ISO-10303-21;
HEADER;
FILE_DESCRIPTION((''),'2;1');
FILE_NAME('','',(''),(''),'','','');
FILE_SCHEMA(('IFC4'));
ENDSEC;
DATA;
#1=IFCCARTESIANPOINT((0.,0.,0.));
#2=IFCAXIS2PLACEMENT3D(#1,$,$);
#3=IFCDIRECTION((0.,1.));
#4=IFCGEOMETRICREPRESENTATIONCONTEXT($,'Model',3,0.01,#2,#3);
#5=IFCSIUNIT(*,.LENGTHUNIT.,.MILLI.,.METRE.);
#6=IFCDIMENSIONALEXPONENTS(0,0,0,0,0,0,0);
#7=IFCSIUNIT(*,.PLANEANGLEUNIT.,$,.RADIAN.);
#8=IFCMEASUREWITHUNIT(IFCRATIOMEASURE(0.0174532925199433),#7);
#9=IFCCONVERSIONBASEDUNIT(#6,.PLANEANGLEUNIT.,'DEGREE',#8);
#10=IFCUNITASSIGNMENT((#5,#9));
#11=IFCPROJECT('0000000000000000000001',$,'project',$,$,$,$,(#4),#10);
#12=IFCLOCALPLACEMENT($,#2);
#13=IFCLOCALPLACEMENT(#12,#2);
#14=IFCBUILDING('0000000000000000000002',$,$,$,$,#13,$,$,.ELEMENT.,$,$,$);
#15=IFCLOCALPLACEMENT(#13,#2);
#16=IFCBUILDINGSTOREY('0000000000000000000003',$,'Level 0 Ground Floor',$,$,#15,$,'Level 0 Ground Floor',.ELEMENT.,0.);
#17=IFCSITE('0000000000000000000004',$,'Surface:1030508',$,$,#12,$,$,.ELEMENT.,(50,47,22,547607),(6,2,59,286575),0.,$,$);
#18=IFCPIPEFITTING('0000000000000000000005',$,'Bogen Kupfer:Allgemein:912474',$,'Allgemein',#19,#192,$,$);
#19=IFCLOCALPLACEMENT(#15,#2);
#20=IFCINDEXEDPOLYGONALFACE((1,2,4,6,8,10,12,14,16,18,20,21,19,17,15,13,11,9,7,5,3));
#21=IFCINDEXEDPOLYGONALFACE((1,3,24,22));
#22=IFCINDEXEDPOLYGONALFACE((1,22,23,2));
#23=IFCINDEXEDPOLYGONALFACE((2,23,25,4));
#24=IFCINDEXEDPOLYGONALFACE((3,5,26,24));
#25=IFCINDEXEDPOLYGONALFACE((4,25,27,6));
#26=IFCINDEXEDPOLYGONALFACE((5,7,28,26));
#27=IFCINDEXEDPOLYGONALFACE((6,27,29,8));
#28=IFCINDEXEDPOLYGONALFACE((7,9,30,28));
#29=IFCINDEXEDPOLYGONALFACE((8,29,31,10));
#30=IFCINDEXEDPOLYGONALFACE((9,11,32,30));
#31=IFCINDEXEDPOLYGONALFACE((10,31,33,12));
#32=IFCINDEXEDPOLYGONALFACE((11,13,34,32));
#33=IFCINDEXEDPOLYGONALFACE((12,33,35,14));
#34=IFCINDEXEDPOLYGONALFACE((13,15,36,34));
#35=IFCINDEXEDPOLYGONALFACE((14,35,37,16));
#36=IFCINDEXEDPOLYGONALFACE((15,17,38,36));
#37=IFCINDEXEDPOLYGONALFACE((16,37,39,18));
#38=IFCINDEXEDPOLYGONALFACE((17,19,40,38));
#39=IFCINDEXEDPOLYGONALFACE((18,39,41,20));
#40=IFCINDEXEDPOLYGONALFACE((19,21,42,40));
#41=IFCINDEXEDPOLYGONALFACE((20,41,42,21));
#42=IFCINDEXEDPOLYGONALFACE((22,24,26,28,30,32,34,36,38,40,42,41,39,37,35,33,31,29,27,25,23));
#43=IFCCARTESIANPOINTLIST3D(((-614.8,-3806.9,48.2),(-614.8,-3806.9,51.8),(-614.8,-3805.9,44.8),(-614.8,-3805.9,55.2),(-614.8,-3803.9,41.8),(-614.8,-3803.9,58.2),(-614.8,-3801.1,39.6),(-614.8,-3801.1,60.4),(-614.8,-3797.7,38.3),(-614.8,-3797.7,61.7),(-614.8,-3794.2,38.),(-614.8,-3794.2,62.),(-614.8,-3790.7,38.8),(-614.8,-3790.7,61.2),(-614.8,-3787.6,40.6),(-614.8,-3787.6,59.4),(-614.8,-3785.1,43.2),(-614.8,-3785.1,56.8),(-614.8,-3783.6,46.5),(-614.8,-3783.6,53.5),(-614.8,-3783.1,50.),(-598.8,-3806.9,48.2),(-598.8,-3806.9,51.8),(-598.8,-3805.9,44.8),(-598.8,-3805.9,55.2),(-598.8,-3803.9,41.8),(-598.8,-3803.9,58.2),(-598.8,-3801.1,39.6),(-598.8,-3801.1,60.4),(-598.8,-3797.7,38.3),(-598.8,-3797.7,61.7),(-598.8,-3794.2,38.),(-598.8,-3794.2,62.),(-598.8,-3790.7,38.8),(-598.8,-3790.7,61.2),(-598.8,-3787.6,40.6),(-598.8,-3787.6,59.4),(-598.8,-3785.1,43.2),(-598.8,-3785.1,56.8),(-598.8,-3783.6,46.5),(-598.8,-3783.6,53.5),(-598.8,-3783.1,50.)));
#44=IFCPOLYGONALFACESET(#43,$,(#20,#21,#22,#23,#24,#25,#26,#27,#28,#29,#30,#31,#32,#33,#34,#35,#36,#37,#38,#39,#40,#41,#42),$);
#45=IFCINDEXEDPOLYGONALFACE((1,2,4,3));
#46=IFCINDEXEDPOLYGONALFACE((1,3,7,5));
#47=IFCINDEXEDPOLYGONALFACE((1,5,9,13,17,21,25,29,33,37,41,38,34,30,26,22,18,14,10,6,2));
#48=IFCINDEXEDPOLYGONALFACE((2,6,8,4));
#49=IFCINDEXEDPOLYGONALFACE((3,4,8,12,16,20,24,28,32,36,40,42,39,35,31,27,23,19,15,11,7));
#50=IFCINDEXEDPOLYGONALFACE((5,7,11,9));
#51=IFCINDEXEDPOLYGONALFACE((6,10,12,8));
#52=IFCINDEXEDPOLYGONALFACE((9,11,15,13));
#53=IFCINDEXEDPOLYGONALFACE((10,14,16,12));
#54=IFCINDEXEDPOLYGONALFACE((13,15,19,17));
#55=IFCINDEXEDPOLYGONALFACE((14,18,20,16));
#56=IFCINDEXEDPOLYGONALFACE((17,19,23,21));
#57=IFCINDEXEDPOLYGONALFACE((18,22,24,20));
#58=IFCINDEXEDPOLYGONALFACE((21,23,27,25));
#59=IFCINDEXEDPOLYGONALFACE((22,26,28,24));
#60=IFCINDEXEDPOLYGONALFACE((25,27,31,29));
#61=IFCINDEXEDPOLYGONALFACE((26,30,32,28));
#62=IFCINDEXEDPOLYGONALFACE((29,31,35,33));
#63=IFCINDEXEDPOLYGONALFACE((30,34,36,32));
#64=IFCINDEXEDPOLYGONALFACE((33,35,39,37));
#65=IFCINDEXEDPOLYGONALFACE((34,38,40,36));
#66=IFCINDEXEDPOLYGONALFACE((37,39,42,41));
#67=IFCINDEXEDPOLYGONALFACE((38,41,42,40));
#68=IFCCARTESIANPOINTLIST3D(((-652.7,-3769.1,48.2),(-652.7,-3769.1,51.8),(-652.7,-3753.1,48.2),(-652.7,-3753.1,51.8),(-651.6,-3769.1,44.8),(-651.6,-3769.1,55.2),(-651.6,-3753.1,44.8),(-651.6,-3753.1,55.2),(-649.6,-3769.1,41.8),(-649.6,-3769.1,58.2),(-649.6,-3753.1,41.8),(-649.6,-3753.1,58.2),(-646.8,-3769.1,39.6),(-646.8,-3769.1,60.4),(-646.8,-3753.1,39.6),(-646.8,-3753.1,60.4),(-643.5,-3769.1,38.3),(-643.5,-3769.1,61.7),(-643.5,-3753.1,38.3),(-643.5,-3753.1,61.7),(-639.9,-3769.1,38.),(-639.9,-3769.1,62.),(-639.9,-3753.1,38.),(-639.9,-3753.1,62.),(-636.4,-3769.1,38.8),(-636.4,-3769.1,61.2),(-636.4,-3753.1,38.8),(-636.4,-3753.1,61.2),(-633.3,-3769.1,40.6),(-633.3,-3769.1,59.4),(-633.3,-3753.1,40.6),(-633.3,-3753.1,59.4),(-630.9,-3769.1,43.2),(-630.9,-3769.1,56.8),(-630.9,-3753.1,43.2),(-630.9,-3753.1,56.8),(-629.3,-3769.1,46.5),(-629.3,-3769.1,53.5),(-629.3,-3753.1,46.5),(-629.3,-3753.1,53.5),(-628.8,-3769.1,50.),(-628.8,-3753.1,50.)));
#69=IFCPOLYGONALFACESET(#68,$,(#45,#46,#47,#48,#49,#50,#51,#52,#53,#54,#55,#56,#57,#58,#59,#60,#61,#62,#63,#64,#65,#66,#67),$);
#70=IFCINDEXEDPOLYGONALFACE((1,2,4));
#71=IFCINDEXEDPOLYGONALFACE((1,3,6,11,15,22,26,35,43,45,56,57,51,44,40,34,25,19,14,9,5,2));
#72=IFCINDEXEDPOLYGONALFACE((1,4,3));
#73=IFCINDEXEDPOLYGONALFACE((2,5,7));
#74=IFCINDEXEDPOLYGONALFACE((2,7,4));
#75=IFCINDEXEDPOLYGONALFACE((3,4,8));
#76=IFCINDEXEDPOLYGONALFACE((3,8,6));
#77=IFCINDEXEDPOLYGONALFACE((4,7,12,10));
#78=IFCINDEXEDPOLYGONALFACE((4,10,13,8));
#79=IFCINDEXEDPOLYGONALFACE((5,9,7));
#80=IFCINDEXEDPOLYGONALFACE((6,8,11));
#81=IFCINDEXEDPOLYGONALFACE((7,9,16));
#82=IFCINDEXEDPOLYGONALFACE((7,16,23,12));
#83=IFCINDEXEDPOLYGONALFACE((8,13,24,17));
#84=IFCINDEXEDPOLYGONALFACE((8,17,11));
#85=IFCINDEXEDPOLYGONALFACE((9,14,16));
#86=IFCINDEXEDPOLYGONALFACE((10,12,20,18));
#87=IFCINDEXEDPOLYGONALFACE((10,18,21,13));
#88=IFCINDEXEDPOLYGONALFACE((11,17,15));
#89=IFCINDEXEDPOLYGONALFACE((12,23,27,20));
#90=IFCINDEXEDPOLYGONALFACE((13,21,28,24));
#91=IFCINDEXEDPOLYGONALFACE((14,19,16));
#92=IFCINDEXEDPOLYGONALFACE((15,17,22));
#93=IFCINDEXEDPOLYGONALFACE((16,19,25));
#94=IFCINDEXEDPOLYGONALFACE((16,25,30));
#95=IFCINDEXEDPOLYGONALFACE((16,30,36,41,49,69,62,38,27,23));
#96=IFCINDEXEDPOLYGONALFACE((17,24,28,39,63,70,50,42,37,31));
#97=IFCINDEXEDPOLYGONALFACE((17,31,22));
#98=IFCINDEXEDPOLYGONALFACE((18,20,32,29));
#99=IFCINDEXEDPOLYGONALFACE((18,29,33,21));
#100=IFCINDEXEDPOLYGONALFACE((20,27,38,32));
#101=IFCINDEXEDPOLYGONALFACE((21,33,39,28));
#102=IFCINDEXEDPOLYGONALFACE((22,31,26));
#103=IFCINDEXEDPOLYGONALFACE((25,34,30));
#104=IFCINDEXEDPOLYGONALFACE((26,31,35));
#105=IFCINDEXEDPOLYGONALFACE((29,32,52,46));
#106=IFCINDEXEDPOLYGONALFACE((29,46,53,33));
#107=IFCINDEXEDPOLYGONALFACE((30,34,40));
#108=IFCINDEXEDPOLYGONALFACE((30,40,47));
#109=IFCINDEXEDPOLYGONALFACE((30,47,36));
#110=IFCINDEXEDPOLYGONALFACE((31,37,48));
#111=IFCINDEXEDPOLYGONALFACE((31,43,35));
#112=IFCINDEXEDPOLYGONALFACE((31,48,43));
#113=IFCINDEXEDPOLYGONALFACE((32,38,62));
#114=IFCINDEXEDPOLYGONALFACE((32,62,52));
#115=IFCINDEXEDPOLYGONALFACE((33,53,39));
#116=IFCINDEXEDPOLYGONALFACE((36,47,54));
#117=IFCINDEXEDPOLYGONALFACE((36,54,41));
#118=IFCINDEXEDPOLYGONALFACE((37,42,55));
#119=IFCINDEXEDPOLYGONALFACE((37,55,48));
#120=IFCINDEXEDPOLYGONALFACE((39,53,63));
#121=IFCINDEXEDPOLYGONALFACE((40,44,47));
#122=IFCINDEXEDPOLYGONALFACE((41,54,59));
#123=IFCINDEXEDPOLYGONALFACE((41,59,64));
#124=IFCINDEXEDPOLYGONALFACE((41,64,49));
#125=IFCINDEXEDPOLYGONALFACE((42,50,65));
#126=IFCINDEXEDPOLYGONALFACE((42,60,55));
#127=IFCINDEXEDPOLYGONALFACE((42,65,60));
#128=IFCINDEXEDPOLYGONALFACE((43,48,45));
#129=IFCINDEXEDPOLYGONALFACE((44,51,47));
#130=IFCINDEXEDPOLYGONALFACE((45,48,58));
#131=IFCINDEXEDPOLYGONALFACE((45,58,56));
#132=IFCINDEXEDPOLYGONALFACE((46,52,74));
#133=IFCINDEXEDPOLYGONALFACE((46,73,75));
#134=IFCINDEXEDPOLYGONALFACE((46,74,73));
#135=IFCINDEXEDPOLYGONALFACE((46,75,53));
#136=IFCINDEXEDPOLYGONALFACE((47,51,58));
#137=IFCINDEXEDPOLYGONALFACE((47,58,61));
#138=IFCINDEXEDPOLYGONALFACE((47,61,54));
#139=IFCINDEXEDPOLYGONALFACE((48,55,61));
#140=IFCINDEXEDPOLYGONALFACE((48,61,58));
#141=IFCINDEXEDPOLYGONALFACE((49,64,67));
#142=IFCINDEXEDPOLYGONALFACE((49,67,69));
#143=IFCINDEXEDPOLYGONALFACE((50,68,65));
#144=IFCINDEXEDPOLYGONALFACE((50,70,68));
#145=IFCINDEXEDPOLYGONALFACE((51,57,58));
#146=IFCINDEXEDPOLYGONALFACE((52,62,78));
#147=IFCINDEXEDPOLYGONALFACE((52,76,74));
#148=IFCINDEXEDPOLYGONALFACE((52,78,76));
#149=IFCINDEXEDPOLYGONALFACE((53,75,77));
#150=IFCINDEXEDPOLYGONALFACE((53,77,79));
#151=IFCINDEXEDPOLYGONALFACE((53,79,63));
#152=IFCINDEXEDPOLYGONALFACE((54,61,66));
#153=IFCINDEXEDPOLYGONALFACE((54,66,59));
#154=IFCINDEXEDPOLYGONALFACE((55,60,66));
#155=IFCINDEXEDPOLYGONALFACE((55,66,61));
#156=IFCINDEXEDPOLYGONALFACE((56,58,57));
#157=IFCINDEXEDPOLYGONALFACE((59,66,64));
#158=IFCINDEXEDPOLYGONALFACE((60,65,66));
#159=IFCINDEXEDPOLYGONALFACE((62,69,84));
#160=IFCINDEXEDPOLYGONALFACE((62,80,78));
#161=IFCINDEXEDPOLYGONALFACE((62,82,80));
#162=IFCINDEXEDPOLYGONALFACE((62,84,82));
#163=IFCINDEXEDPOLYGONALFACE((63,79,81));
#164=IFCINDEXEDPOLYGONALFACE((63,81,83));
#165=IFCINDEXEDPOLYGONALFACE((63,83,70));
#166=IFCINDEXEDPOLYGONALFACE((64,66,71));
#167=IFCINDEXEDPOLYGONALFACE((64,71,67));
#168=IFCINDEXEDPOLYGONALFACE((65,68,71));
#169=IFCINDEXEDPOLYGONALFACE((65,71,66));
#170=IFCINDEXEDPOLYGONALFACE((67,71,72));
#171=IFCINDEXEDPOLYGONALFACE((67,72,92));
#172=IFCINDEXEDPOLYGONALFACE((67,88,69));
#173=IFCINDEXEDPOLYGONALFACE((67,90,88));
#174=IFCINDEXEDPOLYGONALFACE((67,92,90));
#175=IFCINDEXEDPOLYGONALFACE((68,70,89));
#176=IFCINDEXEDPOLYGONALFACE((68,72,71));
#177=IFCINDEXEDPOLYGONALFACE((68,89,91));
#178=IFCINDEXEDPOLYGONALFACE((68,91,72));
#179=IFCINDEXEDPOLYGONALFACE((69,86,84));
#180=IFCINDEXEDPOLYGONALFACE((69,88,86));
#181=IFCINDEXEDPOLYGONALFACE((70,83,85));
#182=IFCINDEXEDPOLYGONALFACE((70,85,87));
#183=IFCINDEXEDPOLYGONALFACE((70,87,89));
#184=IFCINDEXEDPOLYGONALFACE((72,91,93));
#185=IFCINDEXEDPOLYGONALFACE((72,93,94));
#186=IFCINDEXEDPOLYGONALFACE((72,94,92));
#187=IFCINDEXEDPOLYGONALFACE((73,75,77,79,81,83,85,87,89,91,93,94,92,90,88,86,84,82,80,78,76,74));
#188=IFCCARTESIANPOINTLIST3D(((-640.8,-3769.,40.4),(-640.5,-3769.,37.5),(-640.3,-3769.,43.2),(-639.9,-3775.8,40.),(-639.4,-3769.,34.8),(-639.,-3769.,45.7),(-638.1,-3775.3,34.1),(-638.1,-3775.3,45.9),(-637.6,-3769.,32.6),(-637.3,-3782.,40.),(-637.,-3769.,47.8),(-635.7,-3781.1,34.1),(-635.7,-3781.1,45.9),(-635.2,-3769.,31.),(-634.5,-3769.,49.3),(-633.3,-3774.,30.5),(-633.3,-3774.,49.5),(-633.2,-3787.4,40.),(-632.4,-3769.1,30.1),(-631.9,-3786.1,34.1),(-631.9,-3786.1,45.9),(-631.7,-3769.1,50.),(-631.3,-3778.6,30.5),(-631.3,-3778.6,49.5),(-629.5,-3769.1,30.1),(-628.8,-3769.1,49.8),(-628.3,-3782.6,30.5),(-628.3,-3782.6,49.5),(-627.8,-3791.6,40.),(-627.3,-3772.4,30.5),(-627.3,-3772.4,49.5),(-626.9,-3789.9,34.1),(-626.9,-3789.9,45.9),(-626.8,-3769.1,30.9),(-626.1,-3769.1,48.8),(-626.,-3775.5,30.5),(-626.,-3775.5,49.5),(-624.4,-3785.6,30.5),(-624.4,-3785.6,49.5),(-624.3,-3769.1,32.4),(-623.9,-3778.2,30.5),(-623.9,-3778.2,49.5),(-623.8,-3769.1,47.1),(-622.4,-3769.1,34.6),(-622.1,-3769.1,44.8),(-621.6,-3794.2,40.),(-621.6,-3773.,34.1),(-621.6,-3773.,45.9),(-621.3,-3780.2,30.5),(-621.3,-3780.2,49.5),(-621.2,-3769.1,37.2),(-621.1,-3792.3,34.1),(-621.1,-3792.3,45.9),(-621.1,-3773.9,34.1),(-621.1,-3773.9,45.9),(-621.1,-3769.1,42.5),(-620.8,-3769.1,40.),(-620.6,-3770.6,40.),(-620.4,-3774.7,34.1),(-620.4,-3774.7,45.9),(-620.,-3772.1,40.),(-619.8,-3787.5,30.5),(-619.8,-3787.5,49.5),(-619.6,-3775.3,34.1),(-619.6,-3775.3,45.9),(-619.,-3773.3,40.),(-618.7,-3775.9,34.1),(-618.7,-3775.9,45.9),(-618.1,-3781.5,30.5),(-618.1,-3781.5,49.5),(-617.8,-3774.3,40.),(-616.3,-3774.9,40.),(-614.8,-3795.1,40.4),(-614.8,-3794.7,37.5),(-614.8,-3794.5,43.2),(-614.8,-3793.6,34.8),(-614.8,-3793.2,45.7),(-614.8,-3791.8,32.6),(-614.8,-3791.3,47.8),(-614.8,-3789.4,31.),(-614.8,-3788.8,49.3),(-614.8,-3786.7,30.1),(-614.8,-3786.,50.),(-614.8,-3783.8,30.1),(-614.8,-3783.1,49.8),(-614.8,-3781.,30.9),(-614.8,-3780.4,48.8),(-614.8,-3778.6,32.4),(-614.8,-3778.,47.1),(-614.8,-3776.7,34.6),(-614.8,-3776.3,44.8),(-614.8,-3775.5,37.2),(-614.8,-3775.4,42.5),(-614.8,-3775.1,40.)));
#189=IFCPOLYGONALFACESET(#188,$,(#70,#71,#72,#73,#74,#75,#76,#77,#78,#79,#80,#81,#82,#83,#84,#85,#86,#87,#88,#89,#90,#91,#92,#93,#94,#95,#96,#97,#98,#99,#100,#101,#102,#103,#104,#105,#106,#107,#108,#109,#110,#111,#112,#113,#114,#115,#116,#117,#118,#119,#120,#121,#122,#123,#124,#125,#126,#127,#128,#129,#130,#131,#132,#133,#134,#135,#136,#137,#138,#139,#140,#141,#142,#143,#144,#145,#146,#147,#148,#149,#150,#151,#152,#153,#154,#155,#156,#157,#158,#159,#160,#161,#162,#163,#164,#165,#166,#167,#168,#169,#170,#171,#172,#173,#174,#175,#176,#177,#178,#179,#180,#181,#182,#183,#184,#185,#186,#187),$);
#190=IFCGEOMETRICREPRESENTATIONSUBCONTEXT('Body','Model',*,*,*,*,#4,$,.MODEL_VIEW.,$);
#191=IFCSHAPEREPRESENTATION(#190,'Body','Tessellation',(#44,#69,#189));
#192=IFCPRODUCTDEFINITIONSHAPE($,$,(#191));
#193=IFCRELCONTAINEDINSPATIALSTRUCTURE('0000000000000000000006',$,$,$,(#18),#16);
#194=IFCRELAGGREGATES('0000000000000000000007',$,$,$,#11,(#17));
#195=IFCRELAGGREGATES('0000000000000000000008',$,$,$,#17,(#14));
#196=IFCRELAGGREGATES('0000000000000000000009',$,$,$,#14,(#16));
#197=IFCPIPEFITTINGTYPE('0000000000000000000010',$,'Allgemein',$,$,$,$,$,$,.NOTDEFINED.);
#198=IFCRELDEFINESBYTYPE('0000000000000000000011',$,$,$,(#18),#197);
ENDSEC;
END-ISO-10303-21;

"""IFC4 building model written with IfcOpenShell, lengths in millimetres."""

from ifc_helpers import new_model, entity, si_unit, converted_unit, direction, frame, frame_2d, origin, place, context, subcontext, project, spatial, circle, extrude, source, transform, mapped, type_object, type_shapes, element, save


model = new_model("IFC4")

# Units and contexts
model_context = context("Model", 3, precision=0.01, world=origin(), true_north=direction((0.0, 1.0)))
body_context = subcontext(model_context, "Body", "Model", "MODEL_VIEW")
ifc_project = project(units=[si_unit("LENGTHUNIT", "METRE", prefix="MILLI"), converted_unit("PLANEANGLEUNIT", "DEGREE", entity("IfcRatioMeasure", 0.0174532925199433), si_unit("PLANEANGLEUNIT", "RADIAN"), dimensions=[0, 0, 0, 0, 0, 0, 0])], contexts=[model_context])

# Site, building, storey
site_placement = place(None, origin())
site = spatial("IfcSite", under=ifc_project, at=site_placement, Name="Surface:1030508", CompositionType="ELEMENT", RefLatitude=(50, 47, 22, 547607), RefLongitude=(6, 2, 59, 286575), RefElevation=0.0)
building_placement = place(site_placement, origin())
building = spatial("IfcBuilding", under=site, at=building_placement, CompositionType="ELEMENT")
storey_placement = place(building_placement, origin())
storey = spatial("IfcBuildingStorey", under=building, at=storey_placement, Name="Level 0 Ground Floor", LongName="Level 0 Ground Floor", CompositionType="ELEMENT", Elevation=0.0)

# Pipe fitting
pipe_fitting_type_1 = type_object("IfcPipeFittingType", Name="Allgemein", PredefinedType="NOTDEFINED")
ifc_direction_1 = entity("IfcDirection", [0.0, 0.0, -1.0])
trimmed_curve_1 = entity("IfcTrimmedCurve", entity("IfcCircle", entity("IfcAxis2Placement2D", entity("IfcCartesianPoint", [-16.0, 0.0]), entity("IfcDirection", [0.0, 1.0])), 16.0), [entity("IfcParameterValue", 270.0)], [entity("IfcParameterValue", 0.0)], True, "PARAMETER")
shared_shape_1 = source(origin(), body_context, "Body", "SolidModel", [
    extrude(circle(Radius=12.0, at=frame_2d((0.0, 0.0), x_axis=(1.0, 0.0))), frame((0.0, 26.0, 0.0), z_axis=(0.0, 1.0, 0.0), x_axis=(-1.0, 0.0, 0.0)), (0.0, 0.0, 1.0), 16.0),
    extrude(circle(Radius=12.0, at=frame_2d((0.0, 0.0), x_axis=(1.0, 0.0))), frame((-42.0, 0.0, 0.0), z_axis=(1.0, 0.0, 0.0), x_axis=(0.0, 1.0, 0.0)), (0.0, 0.0, 1.0), 16.0),
    entity("IfcSurfaceCurveSweptAreaSolid", entity("IfcCircleProfileDef", "AREA", None, entity("IfcAxis2Placement2D", entity("IfcCartesianPoint", [0.0, 10.0]), entity("IfcDirection", [1.0, 0.0])), 10.0), entity("IfcAxis2Placement3D", entity("IfcCartesianPoint", [-10.0, 26.0, 0.0]), ifc_direction_1, entity("IfcDirection", [1.0, 0.0, 0.0])), trimmed_curve_1, 0.0, 90.0, entity("IfcSurfaceOfLinearExtrusion", entity("IfcArbitraryOpenProfileDef", "CURVE", None, trimmed_curve_1), entity("IfcAxis2Placement3D", entity("IfcCartesianPoint", [0.0, 0.0, -304.8])), ifc_direction_1, 1.0)),
])
type_shapes(pipe_fitting_type_1, [shared_shape_1])
for number, where, z_axis, x_axis, name in (
    (1, (-640.8, -3795.1, 50.0), (0.0, 0.0, 1.0), (0.0, -1.0, 0.0), "Bogen Kupfer:Allgemein:912474"),
):
    element("IfcPipeFitting", number, at=place(storey_placement, frame(where, z_axis=z_axis, x_axis=x_axis)), inside=storey, type_object=pipe_fitting_type_1, Name=name, ObjectType="Allgemein", context=body_context, shape_type="MappedRepresentation", body=[
        mapped(shared_shape_1, transform((0.0, 0.0, 0.0), scale=1.0)),
    ])

save(model, "model.ifc")
